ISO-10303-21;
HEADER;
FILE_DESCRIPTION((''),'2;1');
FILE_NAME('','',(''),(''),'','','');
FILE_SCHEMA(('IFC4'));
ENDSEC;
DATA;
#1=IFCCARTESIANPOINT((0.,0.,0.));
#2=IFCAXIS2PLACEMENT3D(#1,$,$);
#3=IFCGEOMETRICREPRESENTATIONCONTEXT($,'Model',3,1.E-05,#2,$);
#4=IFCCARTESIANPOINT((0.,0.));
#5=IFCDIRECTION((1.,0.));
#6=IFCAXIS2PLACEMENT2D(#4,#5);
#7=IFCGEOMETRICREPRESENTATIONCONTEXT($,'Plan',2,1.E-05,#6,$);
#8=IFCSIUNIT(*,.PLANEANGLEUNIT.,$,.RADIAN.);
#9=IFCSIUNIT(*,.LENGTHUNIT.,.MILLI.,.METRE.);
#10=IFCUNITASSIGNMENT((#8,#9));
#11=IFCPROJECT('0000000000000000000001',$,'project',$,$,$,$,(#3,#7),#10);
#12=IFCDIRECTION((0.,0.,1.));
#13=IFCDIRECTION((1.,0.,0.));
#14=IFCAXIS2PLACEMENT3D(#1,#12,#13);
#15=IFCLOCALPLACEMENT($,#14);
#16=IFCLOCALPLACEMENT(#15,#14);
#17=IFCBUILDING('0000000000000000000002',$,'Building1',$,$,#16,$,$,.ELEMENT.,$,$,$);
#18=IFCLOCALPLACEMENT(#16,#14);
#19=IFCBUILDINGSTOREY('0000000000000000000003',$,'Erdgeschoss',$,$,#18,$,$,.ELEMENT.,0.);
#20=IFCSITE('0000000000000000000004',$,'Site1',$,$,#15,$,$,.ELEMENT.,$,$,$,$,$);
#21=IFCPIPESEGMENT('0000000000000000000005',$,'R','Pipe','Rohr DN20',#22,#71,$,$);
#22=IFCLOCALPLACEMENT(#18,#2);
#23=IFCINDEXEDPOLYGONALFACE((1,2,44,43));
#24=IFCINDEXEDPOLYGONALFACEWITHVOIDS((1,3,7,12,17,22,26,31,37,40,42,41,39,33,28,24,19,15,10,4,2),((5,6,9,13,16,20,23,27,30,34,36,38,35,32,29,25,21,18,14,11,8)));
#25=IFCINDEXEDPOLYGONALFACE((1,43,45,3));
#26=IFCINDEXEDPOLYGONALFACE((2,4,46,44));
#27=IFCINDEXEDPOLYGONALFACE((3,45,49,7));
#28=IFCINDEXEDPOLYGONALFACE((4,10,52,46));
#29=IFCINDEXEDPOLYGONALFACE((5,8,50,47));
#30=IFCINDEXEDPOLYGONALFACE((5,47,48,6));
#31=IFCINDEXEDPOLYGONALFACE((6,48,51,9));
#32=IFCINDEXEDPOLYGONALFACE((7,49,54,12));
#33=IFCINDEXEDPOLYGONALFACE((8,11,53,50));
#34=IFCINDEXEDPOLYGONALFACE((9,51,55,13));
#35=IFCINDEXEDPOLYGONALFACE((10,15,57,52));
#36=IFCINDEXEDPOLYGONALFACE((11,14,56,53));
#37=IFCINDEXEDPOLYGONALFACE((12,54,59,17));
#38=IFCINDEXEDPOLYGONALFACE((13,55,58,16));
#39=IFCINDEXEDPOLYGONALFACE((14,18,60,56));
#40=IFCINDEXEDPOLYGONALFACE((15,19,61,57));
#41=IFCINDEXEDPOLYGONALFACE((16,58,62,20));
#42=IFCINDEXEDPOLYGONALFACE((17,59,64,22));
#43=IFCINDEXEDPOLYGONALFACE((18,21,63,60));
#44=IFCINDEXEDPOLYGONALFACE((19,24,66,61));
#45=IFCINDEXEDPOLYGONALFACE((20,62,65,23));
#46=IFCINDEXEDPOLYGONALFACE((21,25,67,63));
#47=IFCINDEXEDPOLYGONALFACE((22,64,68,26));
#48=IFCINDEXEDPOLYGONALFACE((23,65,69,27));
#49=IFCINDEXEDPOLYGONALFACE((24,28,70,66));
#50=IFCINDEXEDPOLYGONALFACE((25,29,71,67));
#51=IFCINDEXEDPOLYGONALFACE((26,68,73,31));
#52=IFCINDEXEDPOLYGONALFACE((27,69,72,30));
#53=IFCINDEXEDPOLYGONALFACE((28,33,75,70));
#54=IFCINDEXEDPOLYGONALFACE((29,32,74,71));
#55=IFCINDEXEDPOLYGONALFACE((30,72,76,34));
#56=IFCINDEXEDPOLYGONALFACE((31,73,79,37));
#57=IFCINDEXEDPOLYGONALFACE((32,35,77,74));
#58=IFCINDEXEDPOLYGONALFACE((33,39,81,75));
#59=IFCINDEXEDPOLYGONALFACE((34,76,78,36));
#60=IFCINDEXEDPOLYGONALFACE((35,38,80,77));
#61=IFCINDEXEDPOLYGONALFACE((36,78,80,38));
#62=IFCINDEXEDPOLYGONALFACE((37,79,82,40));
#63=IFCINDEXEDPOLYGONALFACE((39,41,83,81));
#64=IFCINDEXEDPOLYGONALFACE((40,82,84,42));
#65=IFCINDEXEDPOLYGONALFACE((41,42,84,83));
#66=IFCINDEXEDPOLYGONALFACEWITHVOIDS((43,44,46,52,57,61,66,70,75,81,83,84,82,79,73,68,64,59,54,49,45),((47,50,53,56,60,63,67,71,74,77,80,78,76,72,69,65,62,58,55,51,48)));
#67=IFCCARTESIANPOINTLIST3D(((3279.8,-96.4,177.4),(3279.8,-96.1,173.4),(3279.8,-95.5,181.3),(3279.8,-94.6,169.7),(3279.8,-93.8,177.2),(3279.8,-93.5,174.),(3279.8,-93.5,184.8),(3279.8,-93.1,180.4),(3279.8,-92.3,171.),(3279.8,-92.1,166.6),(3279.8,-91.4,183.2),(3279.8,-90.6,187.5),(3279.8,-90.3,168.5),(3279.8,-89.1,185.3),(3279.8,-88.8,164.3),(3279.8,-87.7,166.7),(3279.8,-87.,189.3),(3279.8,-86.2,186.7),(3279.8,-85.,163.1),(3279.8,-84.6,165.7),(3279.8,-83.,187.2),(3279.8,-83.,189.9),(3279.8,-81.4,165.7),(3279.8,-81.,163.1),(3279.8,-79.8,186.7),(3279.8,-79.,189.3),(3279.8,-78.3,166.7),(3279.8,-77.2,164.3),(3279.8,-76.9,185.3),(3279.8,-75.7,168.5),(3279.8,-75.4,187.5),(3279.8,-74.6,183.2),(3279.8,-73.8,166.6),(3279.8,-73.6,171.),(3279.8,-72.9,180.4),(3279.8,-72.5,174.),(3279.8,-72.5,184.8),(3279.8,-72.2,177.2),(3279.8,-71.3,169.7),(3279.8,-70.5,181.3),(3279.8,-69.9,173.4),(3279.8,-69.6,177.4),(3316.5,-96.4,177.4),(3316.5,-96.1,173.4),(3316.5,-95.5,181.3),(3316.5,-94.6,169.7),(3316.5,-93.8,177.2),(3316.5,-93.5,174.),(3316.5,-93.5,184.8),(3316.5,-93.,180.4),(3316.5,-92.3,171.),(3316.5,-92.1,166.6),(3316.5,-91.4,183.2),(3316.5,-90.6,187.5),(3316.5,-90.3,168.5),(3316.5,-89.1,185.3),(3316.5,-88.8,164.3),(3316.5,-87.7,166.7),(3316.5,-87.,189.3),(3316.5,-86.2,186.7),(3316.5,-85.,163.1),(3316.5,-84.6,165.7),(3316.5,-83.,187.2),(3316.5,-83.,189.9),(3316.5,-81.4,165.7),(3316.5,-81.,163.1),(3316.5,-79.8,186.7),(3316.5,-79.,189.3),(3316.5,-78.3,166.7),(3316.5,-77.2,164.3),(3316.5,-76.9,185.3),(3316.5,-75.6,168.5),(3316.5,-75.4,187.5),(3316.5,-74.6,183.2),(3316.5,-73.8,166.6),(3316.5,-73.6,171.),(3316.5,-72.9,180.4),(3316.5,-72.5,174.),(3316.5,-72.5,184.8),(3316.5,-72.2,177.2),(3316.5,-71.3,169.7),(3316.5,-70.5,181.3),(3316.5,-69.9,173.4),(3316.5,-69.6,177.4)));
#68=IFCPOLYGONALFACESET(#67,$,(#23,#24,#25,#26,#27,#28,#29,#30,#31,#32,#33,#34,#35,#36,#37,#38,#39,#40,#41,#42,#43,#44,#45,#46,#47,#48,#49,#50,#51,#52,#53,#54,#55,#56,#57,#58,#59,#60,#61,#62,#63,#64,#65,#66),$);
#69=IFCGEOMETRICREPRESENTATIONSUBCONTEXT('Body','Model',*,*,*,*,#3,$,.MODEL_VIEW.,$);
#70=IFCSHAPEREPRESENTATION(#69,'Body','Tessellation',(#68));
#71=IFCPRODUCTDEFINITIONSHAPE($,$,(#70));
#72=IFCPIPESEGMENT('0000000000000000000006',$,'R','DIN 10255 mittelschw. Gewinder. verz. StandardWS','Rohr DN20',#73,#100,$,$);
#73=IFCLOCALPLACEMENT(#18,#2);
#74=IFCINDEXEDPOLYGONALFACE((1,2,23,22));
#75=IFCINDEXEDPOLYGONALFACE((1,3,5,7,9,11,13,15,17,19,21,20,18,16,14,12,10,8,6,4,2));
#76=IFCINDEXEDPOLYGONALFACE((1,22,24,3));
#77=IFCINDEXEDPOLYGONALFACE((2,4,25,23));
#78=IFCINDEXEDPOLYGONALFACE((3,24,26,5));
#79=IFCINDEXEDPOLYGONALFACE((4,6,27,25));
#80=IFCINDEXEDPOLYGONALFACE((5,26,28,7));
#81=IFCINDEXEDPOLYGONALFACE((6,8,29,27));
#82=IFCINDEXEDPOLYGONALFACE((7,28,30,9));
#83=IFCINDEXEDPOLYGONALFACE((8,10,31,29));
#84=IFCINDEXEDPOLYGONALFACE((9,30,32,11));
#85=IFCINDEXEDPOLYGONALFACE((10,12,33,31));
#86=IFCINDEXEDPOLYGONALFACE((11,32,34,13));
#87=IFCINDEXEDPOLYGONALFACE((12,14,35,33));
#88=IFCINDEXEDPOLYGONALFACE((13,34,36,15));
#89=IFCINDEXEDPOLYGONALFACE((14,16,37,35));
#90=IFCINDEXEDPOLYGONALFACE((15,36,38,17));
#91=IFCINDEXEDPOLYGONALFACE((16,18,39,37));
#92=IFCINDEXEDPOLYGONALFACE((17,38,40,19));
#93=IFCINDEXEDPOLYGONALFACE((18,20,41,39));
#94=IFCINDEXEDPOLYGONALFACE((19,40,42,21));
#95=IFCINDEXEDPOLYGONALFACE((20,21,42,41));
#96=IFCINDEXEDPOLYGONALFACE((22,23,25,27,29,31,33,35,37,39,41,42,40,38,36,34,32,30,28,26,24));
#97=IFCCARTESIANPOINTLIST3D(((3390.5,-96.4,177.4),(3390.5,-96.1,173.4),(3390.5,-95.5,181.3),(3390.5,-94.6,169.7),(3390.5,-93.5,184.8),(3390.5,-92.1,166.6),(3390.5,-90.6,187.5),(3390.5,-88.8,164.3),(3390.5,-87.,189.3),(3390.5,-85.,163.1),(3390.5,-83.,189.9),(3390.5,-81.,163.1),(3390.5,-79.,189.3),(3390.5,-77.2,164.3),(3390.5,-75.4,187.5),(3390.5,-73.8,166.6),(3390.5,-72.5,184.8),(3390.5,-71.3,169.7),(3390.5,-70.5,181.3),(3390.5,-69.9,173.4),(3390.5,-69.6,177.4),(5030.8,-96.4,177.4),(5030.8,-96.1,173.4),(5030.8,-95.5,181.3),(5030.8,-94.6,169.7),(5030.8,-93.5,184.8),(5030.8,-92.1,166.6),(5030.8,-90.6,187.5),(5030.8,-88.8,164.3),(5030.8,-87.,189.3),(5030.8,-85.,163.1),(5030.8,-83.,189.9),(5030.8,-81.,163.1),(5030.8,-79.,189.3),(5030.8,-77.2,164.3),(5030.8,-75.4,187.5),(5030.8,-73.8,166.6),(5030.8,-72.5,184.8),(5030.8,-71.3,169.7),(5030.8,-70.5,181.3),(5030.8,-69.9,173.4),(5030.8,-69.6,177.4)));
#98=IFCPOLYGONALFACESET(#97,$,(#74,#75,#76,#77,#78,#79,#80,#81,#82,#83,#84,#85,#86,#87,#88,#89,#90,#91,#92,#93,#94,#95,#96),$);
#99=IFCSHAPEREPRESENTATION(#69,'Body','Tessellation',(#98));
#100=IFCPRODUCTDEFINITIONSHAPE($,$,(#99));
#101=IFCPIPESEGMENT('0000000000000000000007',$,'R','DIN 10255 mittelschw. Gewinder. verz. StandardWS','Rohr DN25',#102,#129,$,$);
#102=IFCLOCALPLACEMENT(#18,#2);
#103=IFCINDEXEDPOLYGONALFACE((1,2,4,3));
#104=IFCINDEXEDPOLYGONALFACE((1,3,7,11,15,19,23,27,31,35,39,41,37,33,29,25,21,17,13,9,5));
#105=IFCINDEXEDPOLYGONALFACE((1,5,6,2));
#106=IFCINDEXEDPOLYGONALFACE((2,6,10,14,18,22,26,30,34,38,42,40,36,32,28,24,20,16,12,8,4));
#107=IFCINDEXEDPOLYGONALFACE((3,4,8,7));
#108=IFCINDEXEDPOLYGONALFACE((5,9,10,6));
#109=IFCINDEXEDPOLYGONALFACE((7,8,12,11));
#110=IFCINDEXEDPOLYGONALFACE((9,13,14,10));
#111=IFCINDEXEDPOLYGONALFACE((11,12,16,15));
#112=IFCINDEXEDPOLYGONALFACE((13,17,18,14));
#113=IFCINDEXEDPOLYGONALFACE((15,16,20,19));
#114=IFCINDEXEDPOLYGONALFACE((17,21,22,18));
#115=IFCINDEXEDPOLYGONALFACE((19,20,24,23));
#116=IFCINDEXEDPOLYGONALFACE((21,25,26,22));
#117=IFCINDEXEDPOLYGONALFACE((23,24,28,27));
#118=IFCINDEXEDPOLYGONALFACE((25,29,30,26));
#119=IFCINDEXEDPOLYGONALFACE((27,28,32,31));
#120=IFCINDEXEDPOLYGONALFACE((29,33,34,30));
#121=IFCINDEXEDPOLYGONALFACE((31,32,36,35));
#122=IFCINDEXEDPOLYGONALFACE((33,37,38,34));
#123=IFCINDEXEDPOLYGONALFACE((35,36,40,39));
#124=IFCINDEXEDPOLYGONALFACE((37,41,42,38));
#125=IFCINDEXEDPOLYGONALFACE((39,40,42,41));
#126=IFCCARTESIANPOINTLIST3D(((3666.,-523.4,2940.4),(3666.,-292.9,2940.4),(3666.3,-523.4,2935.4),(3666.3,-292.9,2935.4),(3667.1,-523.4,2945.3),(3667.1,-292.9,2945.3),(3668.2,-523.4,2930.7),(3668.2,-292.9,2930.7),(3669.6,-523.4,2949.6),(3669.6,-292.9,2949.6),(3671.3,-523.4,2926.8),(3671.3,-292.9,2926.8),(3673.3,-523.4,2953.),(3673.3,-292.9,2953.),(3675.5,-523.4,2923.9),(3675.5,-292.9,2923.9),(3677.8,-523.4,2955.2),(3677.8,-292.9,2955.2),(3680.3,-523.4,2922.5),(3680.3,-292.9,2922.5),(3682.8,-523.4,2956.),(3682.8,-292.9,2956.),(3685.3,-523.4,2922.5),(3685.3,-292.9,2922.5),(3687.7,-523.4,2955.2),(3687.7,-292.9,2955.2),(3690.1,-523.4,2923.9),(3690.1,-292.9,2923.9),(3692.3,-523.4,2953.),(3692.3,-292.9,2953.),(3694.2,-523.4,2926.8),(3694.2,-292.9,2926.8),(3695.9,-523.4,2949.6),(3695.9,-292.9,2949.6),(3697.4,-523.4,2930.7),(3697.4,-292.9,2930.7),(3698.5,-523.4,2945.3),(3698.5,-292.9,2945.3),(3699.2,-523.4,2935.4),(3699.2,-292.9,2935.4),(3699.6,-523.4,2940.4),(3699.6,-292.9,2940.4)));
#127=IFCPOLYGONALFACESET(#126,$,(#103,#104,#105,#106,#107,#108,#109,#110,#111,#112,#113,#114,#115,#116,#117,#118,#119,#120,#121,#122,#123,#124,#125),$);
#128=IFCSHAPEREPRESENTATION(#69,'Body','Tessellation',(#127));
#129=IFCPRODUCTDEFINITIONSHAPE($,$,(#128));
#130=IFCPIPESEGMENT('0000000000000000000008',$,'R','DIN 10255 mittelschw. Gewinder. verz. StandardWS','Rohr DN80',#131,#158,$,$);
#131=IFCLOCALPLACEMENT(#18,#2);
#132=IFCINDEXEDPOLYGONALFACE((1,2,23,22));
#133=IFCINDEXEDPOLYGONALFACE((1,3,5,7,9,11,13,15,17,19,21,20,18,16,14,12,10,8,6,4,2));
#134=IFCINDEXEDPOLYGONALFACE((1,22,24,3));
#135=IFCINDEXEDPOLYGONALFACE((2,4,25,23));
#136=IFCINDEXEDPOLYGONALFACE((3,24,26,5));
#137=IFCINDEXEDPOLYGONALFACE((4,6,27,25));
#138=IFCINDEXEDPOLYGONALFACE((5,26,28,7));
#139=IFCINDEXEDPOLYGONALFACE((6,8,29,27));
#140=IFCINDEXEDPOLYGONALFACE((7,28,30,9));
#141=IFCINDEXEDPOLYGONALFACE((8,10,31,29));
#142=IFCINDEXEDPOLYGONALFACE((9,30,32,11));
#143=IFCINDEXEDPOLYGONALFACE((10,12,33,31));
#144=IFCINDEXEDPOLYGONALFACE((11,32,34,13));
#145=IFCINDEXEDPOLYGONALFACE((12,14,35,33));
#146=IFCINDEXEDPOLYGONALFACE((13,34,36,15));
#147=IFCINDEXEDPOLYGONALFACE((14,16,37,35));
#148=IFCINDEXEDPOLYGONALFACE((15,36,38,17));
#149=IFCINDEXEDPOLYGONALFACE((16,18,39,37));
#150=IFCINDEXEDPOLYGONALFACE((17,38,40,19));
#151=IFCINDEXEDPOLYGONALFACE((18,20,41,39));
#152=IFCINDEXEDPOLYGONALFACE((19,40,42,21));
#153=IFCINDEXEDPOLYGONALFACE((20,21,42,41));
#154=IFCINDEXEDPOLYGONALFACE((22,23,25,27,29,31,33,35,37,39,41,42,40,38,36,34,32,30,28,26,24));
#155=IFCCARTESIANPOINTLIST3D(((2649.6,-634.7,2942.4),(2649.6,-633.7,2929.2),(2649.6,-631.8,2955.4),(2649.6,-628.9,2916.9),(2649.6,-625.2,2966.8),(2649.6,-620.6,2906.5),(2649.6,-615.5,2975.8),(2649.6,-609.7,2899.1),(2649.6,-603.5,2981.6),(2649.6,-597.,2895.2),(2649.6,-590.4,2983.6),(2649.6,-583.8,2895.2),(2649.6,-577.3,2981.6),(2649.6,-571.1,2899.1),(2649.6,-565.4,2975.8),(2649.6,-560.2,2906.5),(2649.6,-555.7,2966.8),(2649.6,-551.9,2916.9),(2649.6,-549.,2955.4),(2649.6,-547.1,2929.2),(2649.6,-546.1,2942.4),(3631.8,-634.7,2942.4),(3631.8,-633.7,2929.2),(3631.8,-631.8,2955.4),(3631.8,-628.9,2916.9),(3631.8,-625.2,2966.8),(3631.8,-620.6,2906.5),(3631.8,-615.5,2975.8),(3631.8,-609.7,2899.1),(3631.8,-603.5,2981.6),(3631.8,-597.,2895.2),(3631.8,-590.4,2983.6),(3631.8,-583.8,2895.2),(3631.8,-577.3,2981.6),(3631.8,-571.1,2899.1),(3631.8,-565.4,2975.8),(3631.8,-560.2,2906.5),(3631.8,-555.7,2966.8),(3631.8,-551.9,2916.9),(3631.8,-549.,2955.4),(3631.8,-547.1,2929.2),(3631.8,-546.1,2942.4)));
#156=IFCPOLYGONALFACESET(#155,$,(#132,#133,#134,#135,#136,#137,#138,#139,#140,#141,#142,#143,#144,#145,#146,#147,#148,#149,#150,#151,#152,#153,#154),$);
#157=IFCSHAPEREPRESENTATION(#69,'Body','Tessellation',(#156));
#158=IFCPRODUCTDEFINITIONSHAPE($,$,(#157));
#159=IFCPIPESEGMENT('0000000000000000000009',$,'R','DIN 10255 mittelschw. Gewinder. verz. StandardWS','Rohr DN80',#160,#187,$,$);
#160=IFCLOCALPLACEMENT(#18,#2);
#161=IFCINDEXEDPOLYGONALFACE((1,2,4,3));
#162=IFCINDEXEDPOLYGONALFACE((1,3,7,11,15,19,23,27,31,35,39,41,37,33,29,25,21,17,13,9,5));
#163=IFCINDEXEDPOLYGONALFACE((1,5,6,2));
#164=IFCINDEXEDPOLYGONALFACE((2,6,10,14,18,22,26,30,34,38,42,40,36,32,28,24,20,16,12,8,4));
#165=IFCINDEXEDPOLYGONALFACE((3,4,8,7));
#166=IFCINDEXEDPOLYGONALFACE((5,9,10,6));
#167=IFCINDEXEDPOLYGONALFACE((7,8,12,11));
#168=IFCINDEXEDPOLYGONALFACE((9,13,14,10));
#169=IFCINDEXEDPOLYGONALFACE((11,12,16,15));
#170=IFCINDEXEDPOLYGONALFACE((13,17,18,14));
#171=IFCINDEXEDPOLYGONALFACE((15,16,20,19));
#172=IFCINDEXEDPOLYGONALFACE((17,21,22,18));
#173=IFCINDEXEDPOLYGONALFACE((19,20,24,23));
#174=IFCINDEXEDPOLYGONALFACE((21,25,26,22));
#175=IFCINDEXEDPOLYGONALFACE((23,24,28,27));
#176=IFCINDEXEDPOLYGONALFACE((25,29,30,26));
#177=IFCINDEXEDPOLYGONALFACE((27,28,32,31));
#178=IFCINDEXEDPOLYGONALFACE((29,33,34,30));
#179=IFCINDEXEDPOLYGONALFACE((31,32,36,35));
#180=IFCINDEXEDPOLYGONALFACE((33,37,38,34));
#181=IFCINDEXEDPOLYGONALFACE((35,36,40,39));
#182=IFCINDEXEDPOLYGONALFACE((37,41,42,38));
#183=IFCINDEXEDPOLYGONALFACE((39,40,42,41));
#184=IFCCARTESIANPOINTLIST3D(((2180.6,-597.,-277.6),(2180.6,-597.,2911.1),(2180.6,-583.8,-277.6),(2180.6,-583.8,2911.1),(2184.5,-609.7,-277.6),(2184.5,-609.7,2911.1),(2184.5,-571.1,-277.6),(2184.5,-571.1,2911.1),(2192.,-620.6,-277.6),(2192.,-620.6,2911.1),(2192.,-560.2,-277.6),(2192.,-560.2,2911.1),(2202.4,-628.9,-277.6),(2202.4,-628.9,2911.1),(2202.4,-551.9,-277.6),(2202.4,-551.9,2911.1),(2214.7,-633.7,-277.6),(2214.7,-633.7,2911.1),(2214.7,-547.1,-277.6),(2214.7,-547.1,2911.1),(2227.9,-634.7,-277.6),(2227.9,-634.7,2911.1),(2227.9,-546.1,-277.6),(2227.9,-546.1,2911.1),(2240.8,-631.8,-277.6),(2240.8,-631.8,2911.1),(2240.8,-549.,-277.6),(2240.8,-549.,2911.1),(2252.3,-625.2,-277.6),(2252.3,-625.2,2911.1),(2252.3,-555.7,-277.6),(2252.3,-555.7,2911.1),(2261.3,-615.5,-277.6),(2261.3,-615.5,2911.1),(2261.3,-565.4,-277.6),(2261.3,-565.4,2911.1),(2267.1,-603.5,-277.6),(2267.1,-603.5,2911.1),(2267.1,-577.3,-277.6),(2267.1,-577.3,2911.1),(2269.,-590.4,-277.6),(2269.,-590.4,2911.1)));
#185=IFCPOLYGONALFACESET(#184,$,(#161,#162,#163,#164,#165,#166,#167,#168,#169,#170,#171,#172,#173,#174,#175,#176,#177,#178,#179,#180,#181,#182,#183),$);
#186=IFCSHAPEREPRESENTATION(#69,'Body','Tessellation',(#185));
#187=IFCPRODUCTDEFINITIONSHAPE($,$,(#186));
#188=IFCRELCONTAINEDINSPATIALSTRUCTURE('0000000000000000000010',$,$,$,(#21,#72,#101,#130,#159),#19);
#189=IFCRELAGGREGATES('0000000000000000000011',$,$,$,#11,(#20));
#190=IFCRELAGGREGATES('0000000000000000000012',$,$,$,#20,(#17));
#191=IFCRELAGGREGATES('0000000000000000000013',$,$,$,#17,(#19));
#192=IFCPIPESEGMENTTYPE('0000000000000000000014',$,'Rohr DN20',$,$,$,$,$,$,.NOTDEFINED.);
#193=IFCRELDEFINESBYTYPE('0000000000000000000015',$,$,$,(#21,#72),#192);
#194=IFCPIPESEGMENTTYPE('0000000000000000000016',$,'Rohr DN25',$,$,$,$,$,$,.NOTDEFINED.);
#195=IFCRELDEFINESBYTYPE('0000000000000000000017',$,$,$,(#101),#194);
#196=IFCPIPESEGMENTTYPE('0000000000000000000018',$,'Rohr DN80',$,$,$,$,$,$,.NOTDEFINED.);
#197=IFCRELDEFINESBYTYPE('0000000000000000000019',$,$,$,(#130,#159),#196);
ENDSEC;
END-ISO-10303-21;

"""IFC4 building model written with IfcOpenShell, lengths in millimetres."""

from ifc_helpers import new_model, si_unit, frame, origin, origin_with_axes, origin_2d_with_axis, place, context, subcontext, project, spatial, circle, hollow_circle, extrude, type_object, element, save


model = new_model("IFC4")

# Units and contexts
model_context = context("Model", 3, precision=1e-05, world=origin())
plan_context = context("Plan", 2, precision=1e-05, world=origin_2d_with_axis())
body_context = subcontext(model_context, "Body", "Model", "MODEL_VIEW")
ifc_project = project(units=[si_unit("PLANEANGLEUNIT", "RADIAN"), si_unit("LENGTHUNIT", "METRE", prefix="MILLI")], contexts=[model_context, plan_context])

# Site, building, storey
site_placement = place(None, origin_with_axes())
site = spatial("IfcSite", under=ifc_project, at=site_placement, Name="Site1", CompositionType="ELEMENT")
building_placement = place(site_placement, origin_with_axes())
building = spatial("IfcBuilding", under=site, at=building_placement, Name="Building1", CompositionType="ELEMENT")
storey_placement = place(building_placement, origin_with_axes())
storey = spatial("IfcBuildingStorey", under=building, at=storey_placement, Name="Erdgeschoss", CompositionType="ELEMENT", Elevation=0.0)

# Pipe segments
pipe_segment_type_1 = type_object("IfcPipeSegmentType", Name="Rohr DN20", PredefinedType="NOTDEFINED")
pipe_segment_1_placement = place(storey_placement, frame((3298.1, -82.8, 176.4), z_axis=(0.0, 0.0, 1.0), x_axis=(1.0, 0.0, 0.0)))
element("IfcPipeSegment", 1, at=pipe_segment_1_placement, inside=storey, type_object=pipe_segment_type_1, Name="R", Description="Pipe", ObjectType="Rohr DN20", context=body_context, shape_type="SolidModel", body=[
    extrude(hollow_circle(Radius=13.4, WallThickness=2.6, at=origin_2d_with_axis()), frame((-18.4, -0.2, 0.0), z_axis=(1.0, 0.000064, -0.000089), x_axis=(0.0, 0.0, 1.0)), (0.0, 0.0, 1.0), 36.7),
])
pipe_segment_2_placement = place(storey_placement, frame((4210.6, -83.1, 176.4), z_axis=(0.0, 0.0, 1.0), x_axis=(1.0, 0.0, 0.0)))
element("IfcPipeSegment", 2, at=pipe_segment_2_placement, inside=storey, type_object=pipe_segment_type_1, Name="R", Description="DIN 10255 mittelschw. Gewinder. verz. StandardWS", ObjectType="Rohr DN20", context=body_context, shape_type="SolidModel", body=[
    extrude(circle(Radius=13.4, at=origin_2d_with_axis()), frame((820.1, 0.1, 0.0), z_axis=(-1.0, 0.000001, -0.000002), x_axis=(0.0, 0.0, 1.0)), (0.0, 0.0, 1.0), 1640.3),
])
pipe_segment_type_2 = type_object("IfcPipeSegmentType", Name="Rohr DN25", PredefinedType="NOTDEFINED")
pipe_segment_3_placement = place(storey_placement, frame((3682.6, -408.1, 2939.1), z_axis=(0.0, 0.0, 1.0), x_axis=(1.0, 0.0, 0.0)))
element("IfcPipeSegment", 3, at=pipe_segment_3_placement, inside=storey, type_object=pipe_segment_type_2, Name="R", Description="DIN 10255 mittelschw. Gewinder. verz. StandardWS", ObjectType="Rohr DN25", context=body_context, shape_type="SolidModel", body=[
    extrude(circle(Radius=16.9, at=origin_2d_with_axis()), frame((0.2, -115.3, 0.0), z_axis=(0.0, 1.0, 0.0), x_axis=(0.0, 0.0, 1.0)), (0.0, 0.0, 1.0), 230.5),
])
pipe_segment_type_3 = type_object("IfcPipeSegmentType", Name="Rohr DN80", PredefinedType="NOTDEFINED")
pipe_segment_4_placement = place(storey_placement, frame((3140.7, -590.3, 2939.1), z_axis=(0.0, 0.0, 1.0), x_axis=(1.0, 0.0, 0.0)))
element("IfcPipeSegment", 4, at=pipe_segment_4_placement, inside=storey, type_object=pipe_segment_type_3, Name="R", Description="DIN 10255 mittelschw. Gewinder. verz. StandardWS", ObjectType="Rohr DN80", context=body_context, shape_type="SolidModel", body=[
    extrude(circle(Radius=44.5, at=origin_2d_with_axis()), frame((-491.1, -0.2, 0.0), z_axis=(1.0, 0.0, 0.0), x_axis=(0.0, 0.0, 1.0)), (0.0, 0.0, 1.0), 982.2),
])
pipe_segment_5_placement = place(storey_placement, frame((2224.6, -590.6, 1316.8), z_axis=(0.0, 0.0, 1.0), x_axis=(1.0, 0.0, 0.0)))
element("IfcPipeSegment", 5, at=pipe_segment_5_placement, inside=storey, type_object=pipe_segment_type_3, Name="R", Description="DIN 10255 mittelschw. Gewinder. verz. StandardWS", ObjectType="Rohr DN80", context=body_context, shape_type="SolidModel", body=[
    extrude(circle(Radius=44.5, at=origin_2d_with_axis()), frame((0.0, 0.1, -1594.4), z_axis=(0.0, 0.0, 1.0), x_axis=(1.0, 0.0, 0.0)), (0.0, 0.0, 1.0), 3188.8),
])

save(model, "model.ifc")
